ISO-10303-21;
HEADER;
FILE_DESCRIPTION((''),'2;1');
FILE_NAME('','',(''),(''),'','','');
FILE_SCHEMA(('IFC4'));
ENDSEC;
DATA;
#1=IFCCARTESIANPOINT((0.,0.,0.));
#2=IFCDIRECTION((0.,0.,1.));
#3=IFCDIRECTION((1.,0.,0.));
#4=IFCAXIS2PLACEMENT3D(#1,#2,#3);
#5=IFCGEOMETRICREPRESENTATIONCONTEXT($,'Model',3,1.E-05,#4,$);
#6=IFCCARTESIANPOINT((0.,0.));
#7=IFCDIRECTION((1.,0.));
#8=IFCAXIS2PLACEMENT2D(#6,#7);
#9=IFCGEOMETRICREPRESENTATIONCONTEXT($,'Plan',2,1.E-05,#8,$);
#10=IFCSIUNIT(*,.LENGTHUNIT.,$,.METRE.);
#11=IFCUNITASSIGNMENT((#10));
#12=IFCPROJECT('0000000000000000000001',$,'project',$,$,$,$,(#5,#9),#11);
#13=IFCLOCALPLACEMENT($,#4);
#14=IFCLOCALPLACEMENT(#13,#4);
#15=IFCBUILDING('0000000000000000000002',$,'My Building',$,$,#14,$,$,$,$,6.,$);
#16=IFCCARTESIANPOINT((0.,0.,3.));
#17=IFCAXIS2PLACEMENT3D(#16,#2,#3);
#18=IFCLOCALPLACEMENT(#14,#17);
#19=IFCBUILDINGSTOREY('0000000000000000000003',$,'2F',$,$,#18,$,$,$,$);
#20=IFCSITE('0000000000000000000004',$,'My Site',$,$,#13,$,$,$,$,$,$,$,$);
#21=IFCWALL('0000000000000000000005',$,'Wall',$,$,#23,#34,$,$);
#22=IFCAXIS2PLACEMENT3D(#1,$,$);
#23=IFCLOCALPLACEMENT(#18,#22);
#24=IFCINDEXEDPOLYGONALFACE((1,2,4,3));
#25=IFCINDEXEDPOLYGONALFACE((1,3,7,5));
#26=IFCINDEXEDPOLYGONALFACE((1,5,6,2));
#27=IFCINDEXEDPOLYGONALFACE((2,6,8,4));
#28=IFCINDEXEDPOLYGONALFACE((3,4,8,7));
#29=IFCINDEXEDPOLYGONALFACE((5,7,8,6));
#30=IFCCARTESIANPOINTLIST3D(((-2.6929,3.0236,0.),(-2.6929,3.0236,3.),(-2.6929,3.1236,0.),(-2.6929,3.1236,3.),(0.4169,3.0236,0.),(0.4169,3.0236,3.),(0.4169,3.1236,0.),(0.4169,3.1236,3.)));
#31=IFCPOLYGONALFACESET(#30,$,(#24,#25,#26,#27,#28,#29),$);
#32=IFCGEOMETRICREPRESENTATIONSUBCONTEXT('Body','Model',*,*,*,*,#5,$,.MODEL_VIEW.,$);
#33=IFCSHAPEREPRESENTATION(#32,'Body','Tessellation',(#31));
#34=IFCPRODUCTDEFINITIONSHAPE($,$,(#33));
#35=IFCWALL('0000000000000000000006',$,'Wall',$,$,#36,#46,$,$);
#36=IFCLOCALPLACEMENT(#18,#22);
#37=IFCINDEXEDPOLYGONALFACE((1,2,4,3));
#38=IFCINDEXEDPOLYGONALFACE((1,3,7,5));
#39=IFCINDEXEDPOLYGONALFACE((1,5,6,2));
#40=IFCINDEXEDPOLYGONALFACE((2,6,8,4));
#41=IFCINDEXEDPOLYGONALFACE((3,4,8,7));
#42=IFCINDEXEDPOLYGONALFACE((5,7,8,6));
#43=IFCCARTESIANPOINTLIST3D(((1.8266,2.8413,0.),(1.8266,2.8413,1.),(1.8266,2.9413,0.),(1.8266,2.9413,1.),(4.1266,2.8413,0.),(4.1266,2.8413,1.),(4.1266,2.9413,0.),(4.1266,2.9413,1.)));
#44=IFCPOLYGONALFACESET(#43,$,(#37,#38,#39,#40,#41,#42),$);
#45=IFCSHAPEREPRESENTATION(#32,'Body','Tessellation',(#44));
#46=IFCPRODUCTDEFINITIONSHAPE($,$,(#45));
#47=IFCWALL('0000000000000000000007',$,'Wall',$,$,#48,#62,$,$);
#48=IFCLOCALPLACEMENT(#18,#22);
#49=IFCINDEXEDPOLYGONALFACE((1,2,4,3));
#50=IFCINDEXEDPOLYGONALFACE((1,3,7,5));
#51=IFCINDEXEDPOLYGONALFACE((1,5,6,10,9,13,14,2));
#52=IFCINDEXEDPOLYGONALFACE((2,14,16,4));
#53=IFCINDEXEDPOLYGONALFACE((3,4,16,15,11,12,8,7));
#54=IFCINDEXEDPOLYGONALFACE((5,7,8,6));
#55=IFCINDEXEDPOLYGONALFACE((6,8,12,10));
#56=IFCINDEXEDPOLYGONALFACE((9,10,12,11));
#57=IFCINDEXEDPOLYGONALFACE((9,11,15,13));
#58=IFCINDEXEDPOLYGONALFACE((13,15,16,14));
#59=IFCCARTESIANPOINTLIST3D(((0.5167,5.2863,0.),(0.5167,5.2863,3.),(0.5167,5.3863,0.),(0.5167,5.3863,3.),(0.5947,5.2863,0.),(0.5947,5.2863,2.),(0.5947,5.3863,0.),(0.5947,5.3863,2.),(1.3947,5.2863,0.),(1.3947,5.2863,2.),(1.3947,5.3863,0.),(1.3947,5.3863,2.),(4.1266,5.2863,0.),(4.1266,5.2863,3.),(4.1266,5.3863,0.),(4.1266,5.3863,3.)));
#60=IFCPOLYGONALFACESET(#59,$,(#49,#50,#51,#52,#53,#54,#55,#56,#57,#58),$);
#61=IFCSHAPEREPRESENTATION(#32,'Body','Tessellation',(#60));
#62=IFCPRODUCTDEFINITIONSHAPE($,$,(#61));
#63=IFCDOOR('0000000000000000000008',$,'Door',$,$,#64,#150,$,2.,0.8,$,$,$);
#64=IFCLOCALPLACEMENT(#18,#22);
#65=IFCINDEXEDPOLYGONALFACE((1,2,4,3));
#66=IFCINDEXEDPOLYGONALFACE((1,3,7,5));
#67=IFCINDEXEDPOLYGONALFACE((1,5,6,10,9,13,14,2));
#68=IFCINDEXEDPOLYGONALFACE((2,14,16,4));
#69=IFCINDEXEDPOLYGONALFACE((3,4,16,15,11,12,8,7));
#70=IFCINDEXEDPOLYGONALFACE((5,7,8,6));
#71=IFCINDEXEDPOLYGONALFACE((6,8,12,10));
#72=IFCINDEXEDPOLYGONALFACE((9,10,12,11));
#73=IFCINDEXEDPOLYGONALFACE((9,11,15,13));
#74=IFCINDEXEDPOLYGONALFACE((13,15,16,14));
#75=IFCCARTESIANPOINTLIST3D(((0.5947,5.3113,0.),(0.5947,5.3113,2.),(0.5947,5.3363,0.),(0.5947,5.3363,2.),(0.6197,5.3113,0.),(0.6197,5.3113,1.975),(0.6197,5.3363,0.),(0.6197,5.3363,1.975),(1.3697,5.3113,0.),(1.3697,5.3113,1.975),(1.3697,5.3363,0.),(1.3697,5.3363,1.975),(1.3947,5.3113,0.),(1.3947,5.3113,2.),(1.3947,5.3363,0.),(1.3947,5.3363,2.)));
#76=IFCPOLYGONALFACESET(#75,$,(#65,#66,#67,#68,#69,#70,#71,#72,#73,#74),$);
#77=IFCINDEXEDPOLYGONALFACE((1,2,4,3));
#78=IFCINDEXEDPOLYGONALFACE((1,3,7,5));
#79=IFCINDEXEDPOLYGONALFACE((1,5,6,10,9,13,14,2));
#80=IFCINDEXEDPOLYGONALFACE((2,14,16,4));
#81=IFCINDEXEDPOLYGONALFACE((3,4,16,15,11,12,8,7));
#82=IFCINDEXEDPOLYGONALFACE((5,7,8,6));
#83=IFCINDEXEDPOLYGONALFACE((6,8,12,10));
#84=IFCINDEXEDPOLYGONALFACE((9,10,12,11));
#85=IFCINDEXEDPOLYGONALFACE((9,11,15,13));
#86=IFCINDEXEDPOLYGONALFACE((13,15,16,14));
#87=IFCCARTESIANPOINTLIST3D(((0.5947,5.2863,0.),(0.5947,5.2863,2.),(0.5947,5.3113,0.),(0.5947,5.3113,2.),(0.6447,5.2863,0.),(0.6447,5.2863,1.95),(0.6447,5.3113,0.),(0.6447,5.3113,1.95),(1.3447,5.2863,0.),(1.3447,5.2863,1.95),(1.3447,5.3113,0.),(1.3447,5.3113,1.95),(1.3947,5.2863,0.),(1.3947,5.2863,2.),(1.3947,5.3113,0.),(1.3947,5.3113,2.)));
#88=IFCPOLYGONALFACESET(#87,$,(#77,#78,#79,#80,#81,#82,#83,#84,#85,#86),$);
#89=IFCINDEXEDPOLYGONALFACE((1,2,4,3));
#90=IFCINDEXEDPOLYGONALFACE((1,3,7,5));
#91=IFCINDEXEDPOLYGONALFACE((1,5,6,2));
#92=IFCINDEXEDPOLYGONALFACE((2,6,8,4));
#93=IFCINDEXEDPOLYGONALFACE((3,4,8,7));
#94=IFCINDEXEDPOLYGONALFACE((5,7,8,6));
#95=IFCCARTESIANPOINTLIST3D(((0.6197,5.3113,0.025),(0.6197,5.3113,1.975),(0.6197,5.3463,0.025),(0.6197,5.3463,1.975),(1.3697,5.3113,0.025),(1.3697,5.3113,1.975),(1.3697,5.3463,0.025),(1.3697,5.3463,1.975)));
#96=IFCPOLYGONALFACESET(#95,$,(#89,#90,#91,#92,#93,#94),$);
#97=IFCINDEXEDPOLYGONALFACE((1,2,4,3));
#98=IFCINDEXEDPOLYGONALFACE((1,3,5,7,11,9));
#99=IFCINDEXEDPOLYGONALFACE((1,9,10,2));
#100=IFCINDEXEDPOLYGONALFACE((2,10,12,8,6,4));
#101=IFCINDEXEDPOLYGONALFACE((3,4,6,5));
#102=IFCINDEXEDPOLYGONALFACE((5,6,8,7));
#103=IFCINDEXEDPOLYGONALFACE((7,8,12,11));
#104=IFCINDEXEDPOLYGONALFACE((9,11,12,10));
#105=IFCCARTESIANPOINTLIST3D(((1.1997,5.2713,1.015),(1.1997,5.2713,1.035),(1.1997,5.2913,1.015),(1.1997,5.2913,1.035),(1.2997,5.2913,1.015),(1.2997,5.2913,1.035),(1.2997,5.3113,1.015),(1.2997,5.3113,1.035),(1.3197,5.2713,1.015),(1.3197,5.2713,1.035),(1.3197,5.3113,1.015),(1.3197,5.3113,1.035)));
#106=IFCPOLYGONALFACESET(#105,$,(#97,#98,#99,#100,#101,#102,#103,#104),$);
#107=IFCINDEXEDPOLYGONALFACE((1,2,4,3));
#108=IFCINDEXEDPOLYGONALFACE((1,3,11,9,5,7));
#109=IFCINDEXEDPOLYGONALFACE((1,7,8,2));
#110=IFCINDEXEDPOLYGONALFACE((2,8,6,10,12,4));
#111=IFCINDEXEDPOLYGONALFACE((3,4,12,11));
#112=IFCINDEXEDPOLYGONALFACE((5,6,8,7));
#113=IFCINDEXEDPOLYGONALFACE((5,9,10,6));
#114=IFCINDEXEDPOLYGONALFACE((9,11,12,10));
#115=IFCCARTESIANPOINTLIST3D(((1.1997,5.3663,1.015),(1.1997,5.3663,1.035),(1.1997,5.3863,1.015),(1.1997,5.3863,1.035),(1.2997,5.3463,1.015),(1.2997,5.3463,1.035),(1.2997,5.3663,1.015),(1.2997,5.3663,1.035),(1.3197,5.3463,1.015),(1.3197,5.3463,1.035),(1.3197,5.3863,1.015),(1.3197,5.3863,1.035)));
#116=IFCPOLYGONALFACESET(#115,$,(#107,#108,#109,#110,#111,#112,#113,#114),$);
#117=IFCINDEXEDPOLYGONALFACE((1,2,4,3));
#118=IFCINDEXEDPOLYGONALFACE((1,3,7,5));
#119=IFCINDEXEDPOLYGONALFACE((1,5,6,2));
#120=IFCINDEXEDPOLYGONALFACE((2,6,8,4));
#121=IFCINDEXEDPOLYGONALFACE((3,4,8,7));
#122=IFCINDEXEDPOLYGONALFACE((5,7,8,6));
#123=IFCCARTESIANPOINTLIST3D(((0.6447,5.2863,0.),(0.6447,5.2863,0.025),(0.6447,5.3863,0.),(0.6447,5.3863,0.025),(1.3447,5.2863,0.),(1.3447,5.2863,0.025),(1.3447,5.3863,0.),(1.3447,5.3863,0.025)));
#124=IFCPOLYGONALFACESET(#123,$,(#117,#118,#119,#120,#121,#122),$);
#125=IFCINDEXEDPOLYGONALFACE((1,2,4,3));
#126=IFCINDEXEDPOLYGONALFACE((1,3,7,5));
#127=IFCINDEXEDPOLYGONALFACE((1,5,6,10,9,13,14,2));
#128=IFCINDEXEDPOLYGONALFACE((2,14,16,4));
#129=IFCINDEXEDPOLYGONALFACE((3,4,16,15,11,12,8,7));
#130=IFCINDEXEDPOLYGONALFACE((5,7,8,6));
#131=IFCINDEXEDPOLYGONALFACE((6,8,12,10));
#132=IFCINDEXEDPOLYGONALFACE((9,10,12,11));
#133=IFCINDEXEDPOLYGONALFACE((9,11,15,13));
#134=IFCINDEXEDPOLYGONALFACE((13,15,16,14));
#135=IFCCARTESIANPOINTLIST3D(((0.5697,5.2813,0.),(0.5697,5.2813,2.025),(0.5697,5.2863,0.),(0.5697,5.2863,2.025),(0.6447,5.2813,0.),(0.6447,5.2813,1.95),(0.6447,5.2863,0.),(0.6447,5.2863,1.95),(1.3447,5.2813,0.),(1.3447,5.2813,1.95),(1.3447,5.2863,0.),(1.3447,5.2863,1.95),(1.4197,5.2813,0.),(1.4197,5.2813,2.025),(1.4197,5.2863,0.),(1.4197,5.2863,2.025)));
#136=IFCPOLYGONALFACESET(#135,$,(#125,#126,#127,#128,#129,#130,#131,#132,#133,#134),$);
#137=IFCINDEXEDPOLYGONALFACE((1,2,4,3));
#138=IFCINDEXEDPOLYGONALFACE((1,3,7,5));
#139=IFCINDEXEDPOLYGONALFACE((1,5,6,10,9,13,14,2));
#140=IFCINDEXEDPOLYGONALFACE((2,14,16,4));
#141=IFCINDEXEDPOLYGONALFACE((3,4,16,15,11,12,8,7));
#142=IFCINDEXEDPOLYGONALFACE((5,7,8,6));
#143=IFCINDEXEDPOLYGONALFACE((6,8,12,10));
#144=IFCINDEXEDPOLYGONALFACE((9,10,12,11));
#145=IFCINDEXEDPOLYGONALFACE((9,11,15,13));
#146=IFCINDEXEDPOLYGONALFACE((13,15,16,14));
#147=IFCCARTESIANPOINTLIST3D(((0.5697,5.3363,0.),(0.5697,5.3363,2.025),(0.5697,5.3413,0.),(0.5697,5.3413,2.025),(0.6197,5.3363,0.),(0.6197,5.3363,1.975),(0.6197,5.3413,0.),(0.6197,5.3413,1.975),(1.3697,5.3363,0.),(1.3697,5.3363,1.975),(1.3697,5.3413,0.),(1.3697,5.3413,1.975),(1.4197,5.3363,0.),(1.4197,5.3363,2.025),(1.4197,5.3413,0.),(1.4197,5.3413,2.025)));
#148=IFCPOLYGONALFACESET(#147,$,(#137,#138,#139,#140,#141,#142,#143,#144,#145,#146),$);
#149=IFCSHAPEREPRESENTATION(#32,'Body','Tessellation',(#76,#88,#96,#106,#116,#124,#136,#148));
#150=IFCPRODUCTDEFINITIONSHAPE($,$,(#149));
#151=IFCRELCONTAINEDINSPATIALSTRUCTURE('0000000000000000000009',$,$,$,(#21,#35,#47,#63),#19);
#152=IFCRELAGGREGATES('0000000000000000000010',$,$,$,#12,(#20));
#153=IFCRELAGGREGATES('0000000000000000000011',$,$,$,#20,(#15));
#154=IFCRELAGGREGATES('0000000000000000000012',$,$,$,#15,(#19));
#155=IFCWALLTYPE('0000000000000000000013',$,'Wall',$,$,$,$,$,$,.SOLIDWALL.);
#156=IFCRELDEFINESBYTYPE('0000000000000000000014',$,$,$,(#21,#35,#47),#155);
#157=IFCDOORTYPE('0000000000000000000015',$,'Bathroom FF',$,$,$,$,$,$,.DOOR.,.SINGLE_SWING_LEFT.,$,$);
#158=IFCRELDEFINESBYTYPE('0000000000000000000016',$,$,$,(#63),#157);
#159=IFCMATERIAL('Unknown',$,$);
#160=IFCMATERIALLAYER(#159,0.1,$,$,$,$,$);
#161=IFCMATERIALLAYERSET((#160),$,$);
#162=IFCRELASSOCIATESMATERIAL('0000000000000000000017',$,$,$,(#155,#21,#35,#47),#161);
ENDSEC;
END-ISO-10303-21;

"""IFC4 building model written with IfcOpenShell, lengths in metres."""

from ifc_helpers import new_model, entity, si_unit, frame, origin_with_axes, origin_2d_with_axis, place, context, subcontext, project, spatial, line, indexed_curve, outline, extrude, shape, source, transform, mapped, material, layer, layer_set, layer_usage, type_object, type_shapes, element, fill, save


model = new_model("IFC4")

# Units and contexts
model_context = context("Model", 3, precision=1e-05, world=origin_with_axes())
plan_context = context("Plan", 2, precision=1e-05, world=origin_2d_with_axis())
body_context_1 = subcontext(model_context, "Body", "Model", "MODEL_VIEW")
body_context_2 = subcontext(plan_context, "Body", "Plan", "PLAN_VIEW")
ifc_project = project(units=[si_unit("LENGTHUNIT", "METRE")], contexts=[model_context, plan_context])

# Site, building, storey
site_placement = place(None, origin_with_axes())
site = spatial("IfcSite", under=ifc_project, at=site_placement, Name="My Site")
building_placement = place(site_placement, origin_with_axes())
building = spatial("IfcBuilding", under=site, at=building_placement, Name="My Building", ElevationOfTerrain=6.0)
storey_placement = place(building_placement, frame((0.0, 0.0, 3.0), z_axis=(0.0, 0.0, 1.0), x_axis=(1.0, 0.0, 0.0)))
storey = spatial("IfcBuildingStorey", under=building, at=storey_placement, Name="2F")

# Shared definitions
ifc_material_1 = material(Name="Unknown")
ifc_layer = layer(ifc_material_1, 0.1)
ifc_layer_set = layer_set([ifc_layer])
wall_type = type_object("IfcWallType", Name="Wall", PredefinedType="SOLIDWALL", material=ifc_layer_set)

# Walls
ifc_layer_usage_1 = layer_usage(ifc_layer_set, "AXIS2", "POSITIVE", 0.0)
wall_1_placement = place(storey_placement, frame((0.4169, 3.1236, 0.0), z_axis=(0.0, 0.0, 1.0), x_axis=(-1.0, 0.0, 0.0)))
element("IfcWall", 1, at=wall_1_placement, inside=storey, type_object=wall_type, material=ifc_layer_usage_1, Name="Wall", context=body_context_1, shape_type="SweptSolid", body=[
    extrude(outline(indexed_curve([(0.0, 0.0), (0.0, 0.1), (3.1098, 0.1), (3.1098, 0.0)], segments=[line(1, 2, 3, 4, 1)])), origin_with_axes(), (0.0, 0.0, 1.0), 3.0),
])
ifc_layer_usage_2 = layer_usage(ifc_layer_set, "AXIS2", "POSITIVE", 0.0)
wall_2_placement = place(storey_placement, frame((4.1266, 2.9413, 0.0), z_axis=(0.0, 0.0, 1.0), x_axis=(-1.0, 0.0, 0.0)))
element("IfcWall", 2, at=wall_2_placement, inside=storey, type_object=wall_type, material=ifc_layer_usage_2, Name="Wall", context=body_context_1, shape_type="SweptSolid", body=[
    extrude(outline(indexed_curve([(0.0, 0.0), (0.0, 0.1), (2.3, 0.1), (2.3, 0.0)], segments=[line(1, 2, 3, 4, 1)])), origin_with_axes(), (0.0, 0.0, 1.0), 1.0),
])

# Wall, opening, door
ifc_layer_usage_3 = layer_usage(ifc_layer_set, "AXIS2", "POSITIVE", 0.0)
wall_3_placement = place(storey_placement, frame((4.1266, 5.3863, 0.0), z_axis=(0.0, 0.0, 1.0), x_axis=(-1.0, 0.0, 0.0)))
wall_3 = element("IfcWall", 3, at=wall_3_placement, inside=storey, type_object=wall_type, material=ifc_layer_usage_3, Name="Wall", context=body_context_1, shape_type="SweptSolid", body=[
    extrude(outline(indexed_curve([(0.0, 0.0), (0.0, 0.1), (3.6099, 0.1), (3.6099, 0.0)], segments=[line(1, 2, 3, 4, 1)])), origin_with_axes(), (0.0, 0.0, 1.0), 3.0),
])
shared_shape_1 = source(origin_with_axes(), body_context_1, "Body", "SweptSolid", [
    extrude(outline(indexed_curve([(0.0, 0.0), (0.8, 0.0), (0.8, 2.0), (0.0, 2.0)], segments=[line(1, 2, 3, 4, 1)])), frame((0.0, -0.6, 0.0), z_axis=(0.0, -1.0, 0.0), x_axis=(1.0, 0.0, 0.0)), (0.0, 0.0, -1.0), 1.2),
])
opening_1_placement = place(wall_3_placement, frame((3.5319, 0.1, 0.0), z_axis=(0.0, 0.0, 1.0), x_axis=(-1.0, 0.0, 0.0)))
opening_1 = element("IfcOpeningElement", 4, at=opening_1_placement, cuts=wall_3, PredefinedType="OPENING", context=body_context_1, shape_type="MappedRepresentation", body=[
    mapped(shared_shape_1, transform((0.0, 0.0, 0.0), x_axis=(1.0, 0.0, 0.0), y_axis=(0.0, 1.0, 0.0), z_axis=(0.0, 0.0, 1.0), scale=1.0)),
])
door_type = type_object("IfcDoorType", Name="Bathroom FF", OperationType="SINGLE_SWING_LEFT", PredefinedType="DOOR")
shared_shape_2 = source(origin_with_axes(), body_context_1, "Body", "SweptSolid", [
    extrude(outline(indexed_curve([(0.0, 0.0), (0.0, 2.0), (0.8, 2.0), (0.8, 0.0), (0.775, 0.0), (0.775, 1.975), (0.025, 1.975), (0.025, 0.0)], segments=[line(1, 2, 3, 4, 5, 6, 7, 8, 1)])), frame((0.0, 0.025, 0.0), z_axis=(0.0, -1.0, 0.0), x_axis=(1.0, 0.0, 0.0)), (0.0, 0.0, -1.0), 0.025),
    extrude(outline(indexed_curve([(0.0, 0.0), (0.0, 2.0), (0.8, 2.0), (0.8, 0.0), (0.75, 0.0), (0.75, 1.95), (0.05, 1.95), (0.05, 0.0)], segments=[line(1, 2, 3, 4, 5, 6, 7, 8, 1)])), frame((0.0, 0.0, 0.0), z_axis=(0.0, -1.0, 0.0), x_axis=(1.0, 0.0, 0.0)), (0.0, 0.0, -1.0), 0.025),
    extrude(outline(indexed_curve([(0.0, 0.0), (0.75, 0.0), (0.75, 0.035), (0.0, 0.035)], segments=[line(1, 2, 3, 4, 1)])), frame((0.025, 0.025, 0.025), z_axis=(0.0, 0.0, 1.0), x_axis=(1.0, 0.0, 0.0)), (0.0, 0.0, 1.0), 1.95),
    extrude(outline(indexed_curve([(0.0, 0.0), (0.0, -0.04), (-0.12, -0.04), (-0.12, -0.02), (-0.02, -0.02), (-0.02, 0.0)], segments=[line(1, 2, 3, 4, 5, 6, 1)])), frame((0.725, 0.025, 1.015), z_axis=(0.0, 0.0, 1.0), x_axis=(1.0, 0.0, 0.0)), (0.0, 0.0, 1.0), 0.02),
    extrude(outline(indexed_curve([(0.0, 0.0), (0.0, 0.04), (-0.12, 0.04), (-0.12, 0.02), (-0.02, 0.02), (-0.02, 0.0)], segments=[line(1, 2, 3, 4, 5, 6, 1)])), frame((0.725, 0.06, 1.015), z_axis=(0.0, 0.0, 1.0), x_axis=(1.0, 0.0, 0.0)), (0.0, 0.0, 1.0), 0.02),
    extrude(outline(indexed_curve([(0.0, 0.0), (0.7, 0.0), (0.7, 0.1), (0.0, 0.1)], segments=[line(1, 2, 3, 4, 1)])), frame((0.05, 0.0, 0.0), z_axis=(0.0, 0.0, 1.0), x_axis=(1.0, 0.0, 0.0)), (0.0, 0.0, 1.0), 0.025),
    extrude(outline(indexed_curve([(0.0, 0.0), (0.0, 2.025), (0.85, 2.025), (0.85, 0.0), (0.775, 0.0), (0.775, 1.95), (0.075, 1.95), (0.075, 0.0)], segments=[line(1, 2, 3, 4, 5, 6, 7, 8, 1)])), frame((-0.025, -0.005, 0.0), z_axis=(0.0, -1.0, 0.0), x_axis=(1.0, 0.0, 0.0)), (0.0, 0.0, -1.0), 0.005),
    extrude(outline(indexed_curve([(0.0, 0.0), (0.0, 2.025), (0.85, 2.025), (0.85, 0.0), (0.8, 0.0), (0.8, 1.975), (0.05, 1.975), (0.05, 0.0)], segments=[line(1, 2, 3, 4, 5, 6, 7, 8, 1)])), frame((-0.025, 0.05, 0.0), z_axis=(0.0, -1.0, 0.0), x_axis=(1.0, 0.0, 0.0)), (0.0, 0.0, -1.0), 0.005),
])
shared_shape_3 = source(origin_with_axes(), body_context_2, "Body", "Curve2D", [
    entity("IfcIndexedPolyCurve", entity("IfcCartesianPointList2D", [[0.0, 0.0], [0.0, 0.05], [0.025, 0.05], [0.025, 0.025], [0.05, 0.025], [0.05, 0.0]]), [entity("IfcLineIndex", [1, 2, 3, 4, 5, 6, 1])]),
    entity("IfcIndexedPolyCurve", entity("IfcCartesianPointList2D", [[0.8, 0.0], [0.8, 0.05], [0.775, 0.05], [0.775, 0.025], [0.75, 0.025], [0.75, 0.0]]), [entity("IfcLineIndex", [1, 2, 3, 4, 5, 6, 1])]),
    entity("IfcTrimmedCurve", entity("IfcEllipse", entity("IfcAxis2Placement2D", entity("IfcCartesianPoint", [0.06, 0.05]), entity("IfcDirection", [1.0, 0.0])), 0.715, 0.75), [entity("IfcCartesianPoint", [0.775, 0.05])], [entity("IfcCartesianPoint", [0.06, 0.8])], True, "CARTESIAN"),
    entity("IfcIndexedPolyCurve", entity("IfcCartesianPointList2D", [[0.025, 0.05], [0.06, 0.05], [0.06, 0.8], [0.025, 0.8]]), [entity("IfcLineIndex", [1, 2, 3, 4, 1])]),
])
type_shapes(door_type, [shared_shape_2, shared_shape_3])
door_placement = place(opening_1_placement, origin_with_axes())
door = element("IfcDoor", 5, at=door_placement, inside=storey, type_object=door_type, Name="Door", OverallHeight=2.0, OverallWidth=0.8, shapes=[
    shape(body_context_1, "Body", "MappedRepresentation", [mapped(shared_shape_2, transform((0.0, 0.0, 0.0), x_axis=(1.0, 0.0, 0.0), y_axis=(0.0, 1.0, 0.0), z_axis=(0.0, 0.0, 1.0), scale=1.0))]),
    shape(body_context_2, "Body", "MappedRepresentation", [mapped(shared_shape_3, transform((0.0, 0.0, 0.0), x_axis=(1.0, 0.0, 0.0), y_axis=(0.0, 1.0, 0.0), z_axis=(0.0, 0.0, 1.0), scale=1.0))]),
])
fill(opening_1, door)

save(model, "model.ifc")
